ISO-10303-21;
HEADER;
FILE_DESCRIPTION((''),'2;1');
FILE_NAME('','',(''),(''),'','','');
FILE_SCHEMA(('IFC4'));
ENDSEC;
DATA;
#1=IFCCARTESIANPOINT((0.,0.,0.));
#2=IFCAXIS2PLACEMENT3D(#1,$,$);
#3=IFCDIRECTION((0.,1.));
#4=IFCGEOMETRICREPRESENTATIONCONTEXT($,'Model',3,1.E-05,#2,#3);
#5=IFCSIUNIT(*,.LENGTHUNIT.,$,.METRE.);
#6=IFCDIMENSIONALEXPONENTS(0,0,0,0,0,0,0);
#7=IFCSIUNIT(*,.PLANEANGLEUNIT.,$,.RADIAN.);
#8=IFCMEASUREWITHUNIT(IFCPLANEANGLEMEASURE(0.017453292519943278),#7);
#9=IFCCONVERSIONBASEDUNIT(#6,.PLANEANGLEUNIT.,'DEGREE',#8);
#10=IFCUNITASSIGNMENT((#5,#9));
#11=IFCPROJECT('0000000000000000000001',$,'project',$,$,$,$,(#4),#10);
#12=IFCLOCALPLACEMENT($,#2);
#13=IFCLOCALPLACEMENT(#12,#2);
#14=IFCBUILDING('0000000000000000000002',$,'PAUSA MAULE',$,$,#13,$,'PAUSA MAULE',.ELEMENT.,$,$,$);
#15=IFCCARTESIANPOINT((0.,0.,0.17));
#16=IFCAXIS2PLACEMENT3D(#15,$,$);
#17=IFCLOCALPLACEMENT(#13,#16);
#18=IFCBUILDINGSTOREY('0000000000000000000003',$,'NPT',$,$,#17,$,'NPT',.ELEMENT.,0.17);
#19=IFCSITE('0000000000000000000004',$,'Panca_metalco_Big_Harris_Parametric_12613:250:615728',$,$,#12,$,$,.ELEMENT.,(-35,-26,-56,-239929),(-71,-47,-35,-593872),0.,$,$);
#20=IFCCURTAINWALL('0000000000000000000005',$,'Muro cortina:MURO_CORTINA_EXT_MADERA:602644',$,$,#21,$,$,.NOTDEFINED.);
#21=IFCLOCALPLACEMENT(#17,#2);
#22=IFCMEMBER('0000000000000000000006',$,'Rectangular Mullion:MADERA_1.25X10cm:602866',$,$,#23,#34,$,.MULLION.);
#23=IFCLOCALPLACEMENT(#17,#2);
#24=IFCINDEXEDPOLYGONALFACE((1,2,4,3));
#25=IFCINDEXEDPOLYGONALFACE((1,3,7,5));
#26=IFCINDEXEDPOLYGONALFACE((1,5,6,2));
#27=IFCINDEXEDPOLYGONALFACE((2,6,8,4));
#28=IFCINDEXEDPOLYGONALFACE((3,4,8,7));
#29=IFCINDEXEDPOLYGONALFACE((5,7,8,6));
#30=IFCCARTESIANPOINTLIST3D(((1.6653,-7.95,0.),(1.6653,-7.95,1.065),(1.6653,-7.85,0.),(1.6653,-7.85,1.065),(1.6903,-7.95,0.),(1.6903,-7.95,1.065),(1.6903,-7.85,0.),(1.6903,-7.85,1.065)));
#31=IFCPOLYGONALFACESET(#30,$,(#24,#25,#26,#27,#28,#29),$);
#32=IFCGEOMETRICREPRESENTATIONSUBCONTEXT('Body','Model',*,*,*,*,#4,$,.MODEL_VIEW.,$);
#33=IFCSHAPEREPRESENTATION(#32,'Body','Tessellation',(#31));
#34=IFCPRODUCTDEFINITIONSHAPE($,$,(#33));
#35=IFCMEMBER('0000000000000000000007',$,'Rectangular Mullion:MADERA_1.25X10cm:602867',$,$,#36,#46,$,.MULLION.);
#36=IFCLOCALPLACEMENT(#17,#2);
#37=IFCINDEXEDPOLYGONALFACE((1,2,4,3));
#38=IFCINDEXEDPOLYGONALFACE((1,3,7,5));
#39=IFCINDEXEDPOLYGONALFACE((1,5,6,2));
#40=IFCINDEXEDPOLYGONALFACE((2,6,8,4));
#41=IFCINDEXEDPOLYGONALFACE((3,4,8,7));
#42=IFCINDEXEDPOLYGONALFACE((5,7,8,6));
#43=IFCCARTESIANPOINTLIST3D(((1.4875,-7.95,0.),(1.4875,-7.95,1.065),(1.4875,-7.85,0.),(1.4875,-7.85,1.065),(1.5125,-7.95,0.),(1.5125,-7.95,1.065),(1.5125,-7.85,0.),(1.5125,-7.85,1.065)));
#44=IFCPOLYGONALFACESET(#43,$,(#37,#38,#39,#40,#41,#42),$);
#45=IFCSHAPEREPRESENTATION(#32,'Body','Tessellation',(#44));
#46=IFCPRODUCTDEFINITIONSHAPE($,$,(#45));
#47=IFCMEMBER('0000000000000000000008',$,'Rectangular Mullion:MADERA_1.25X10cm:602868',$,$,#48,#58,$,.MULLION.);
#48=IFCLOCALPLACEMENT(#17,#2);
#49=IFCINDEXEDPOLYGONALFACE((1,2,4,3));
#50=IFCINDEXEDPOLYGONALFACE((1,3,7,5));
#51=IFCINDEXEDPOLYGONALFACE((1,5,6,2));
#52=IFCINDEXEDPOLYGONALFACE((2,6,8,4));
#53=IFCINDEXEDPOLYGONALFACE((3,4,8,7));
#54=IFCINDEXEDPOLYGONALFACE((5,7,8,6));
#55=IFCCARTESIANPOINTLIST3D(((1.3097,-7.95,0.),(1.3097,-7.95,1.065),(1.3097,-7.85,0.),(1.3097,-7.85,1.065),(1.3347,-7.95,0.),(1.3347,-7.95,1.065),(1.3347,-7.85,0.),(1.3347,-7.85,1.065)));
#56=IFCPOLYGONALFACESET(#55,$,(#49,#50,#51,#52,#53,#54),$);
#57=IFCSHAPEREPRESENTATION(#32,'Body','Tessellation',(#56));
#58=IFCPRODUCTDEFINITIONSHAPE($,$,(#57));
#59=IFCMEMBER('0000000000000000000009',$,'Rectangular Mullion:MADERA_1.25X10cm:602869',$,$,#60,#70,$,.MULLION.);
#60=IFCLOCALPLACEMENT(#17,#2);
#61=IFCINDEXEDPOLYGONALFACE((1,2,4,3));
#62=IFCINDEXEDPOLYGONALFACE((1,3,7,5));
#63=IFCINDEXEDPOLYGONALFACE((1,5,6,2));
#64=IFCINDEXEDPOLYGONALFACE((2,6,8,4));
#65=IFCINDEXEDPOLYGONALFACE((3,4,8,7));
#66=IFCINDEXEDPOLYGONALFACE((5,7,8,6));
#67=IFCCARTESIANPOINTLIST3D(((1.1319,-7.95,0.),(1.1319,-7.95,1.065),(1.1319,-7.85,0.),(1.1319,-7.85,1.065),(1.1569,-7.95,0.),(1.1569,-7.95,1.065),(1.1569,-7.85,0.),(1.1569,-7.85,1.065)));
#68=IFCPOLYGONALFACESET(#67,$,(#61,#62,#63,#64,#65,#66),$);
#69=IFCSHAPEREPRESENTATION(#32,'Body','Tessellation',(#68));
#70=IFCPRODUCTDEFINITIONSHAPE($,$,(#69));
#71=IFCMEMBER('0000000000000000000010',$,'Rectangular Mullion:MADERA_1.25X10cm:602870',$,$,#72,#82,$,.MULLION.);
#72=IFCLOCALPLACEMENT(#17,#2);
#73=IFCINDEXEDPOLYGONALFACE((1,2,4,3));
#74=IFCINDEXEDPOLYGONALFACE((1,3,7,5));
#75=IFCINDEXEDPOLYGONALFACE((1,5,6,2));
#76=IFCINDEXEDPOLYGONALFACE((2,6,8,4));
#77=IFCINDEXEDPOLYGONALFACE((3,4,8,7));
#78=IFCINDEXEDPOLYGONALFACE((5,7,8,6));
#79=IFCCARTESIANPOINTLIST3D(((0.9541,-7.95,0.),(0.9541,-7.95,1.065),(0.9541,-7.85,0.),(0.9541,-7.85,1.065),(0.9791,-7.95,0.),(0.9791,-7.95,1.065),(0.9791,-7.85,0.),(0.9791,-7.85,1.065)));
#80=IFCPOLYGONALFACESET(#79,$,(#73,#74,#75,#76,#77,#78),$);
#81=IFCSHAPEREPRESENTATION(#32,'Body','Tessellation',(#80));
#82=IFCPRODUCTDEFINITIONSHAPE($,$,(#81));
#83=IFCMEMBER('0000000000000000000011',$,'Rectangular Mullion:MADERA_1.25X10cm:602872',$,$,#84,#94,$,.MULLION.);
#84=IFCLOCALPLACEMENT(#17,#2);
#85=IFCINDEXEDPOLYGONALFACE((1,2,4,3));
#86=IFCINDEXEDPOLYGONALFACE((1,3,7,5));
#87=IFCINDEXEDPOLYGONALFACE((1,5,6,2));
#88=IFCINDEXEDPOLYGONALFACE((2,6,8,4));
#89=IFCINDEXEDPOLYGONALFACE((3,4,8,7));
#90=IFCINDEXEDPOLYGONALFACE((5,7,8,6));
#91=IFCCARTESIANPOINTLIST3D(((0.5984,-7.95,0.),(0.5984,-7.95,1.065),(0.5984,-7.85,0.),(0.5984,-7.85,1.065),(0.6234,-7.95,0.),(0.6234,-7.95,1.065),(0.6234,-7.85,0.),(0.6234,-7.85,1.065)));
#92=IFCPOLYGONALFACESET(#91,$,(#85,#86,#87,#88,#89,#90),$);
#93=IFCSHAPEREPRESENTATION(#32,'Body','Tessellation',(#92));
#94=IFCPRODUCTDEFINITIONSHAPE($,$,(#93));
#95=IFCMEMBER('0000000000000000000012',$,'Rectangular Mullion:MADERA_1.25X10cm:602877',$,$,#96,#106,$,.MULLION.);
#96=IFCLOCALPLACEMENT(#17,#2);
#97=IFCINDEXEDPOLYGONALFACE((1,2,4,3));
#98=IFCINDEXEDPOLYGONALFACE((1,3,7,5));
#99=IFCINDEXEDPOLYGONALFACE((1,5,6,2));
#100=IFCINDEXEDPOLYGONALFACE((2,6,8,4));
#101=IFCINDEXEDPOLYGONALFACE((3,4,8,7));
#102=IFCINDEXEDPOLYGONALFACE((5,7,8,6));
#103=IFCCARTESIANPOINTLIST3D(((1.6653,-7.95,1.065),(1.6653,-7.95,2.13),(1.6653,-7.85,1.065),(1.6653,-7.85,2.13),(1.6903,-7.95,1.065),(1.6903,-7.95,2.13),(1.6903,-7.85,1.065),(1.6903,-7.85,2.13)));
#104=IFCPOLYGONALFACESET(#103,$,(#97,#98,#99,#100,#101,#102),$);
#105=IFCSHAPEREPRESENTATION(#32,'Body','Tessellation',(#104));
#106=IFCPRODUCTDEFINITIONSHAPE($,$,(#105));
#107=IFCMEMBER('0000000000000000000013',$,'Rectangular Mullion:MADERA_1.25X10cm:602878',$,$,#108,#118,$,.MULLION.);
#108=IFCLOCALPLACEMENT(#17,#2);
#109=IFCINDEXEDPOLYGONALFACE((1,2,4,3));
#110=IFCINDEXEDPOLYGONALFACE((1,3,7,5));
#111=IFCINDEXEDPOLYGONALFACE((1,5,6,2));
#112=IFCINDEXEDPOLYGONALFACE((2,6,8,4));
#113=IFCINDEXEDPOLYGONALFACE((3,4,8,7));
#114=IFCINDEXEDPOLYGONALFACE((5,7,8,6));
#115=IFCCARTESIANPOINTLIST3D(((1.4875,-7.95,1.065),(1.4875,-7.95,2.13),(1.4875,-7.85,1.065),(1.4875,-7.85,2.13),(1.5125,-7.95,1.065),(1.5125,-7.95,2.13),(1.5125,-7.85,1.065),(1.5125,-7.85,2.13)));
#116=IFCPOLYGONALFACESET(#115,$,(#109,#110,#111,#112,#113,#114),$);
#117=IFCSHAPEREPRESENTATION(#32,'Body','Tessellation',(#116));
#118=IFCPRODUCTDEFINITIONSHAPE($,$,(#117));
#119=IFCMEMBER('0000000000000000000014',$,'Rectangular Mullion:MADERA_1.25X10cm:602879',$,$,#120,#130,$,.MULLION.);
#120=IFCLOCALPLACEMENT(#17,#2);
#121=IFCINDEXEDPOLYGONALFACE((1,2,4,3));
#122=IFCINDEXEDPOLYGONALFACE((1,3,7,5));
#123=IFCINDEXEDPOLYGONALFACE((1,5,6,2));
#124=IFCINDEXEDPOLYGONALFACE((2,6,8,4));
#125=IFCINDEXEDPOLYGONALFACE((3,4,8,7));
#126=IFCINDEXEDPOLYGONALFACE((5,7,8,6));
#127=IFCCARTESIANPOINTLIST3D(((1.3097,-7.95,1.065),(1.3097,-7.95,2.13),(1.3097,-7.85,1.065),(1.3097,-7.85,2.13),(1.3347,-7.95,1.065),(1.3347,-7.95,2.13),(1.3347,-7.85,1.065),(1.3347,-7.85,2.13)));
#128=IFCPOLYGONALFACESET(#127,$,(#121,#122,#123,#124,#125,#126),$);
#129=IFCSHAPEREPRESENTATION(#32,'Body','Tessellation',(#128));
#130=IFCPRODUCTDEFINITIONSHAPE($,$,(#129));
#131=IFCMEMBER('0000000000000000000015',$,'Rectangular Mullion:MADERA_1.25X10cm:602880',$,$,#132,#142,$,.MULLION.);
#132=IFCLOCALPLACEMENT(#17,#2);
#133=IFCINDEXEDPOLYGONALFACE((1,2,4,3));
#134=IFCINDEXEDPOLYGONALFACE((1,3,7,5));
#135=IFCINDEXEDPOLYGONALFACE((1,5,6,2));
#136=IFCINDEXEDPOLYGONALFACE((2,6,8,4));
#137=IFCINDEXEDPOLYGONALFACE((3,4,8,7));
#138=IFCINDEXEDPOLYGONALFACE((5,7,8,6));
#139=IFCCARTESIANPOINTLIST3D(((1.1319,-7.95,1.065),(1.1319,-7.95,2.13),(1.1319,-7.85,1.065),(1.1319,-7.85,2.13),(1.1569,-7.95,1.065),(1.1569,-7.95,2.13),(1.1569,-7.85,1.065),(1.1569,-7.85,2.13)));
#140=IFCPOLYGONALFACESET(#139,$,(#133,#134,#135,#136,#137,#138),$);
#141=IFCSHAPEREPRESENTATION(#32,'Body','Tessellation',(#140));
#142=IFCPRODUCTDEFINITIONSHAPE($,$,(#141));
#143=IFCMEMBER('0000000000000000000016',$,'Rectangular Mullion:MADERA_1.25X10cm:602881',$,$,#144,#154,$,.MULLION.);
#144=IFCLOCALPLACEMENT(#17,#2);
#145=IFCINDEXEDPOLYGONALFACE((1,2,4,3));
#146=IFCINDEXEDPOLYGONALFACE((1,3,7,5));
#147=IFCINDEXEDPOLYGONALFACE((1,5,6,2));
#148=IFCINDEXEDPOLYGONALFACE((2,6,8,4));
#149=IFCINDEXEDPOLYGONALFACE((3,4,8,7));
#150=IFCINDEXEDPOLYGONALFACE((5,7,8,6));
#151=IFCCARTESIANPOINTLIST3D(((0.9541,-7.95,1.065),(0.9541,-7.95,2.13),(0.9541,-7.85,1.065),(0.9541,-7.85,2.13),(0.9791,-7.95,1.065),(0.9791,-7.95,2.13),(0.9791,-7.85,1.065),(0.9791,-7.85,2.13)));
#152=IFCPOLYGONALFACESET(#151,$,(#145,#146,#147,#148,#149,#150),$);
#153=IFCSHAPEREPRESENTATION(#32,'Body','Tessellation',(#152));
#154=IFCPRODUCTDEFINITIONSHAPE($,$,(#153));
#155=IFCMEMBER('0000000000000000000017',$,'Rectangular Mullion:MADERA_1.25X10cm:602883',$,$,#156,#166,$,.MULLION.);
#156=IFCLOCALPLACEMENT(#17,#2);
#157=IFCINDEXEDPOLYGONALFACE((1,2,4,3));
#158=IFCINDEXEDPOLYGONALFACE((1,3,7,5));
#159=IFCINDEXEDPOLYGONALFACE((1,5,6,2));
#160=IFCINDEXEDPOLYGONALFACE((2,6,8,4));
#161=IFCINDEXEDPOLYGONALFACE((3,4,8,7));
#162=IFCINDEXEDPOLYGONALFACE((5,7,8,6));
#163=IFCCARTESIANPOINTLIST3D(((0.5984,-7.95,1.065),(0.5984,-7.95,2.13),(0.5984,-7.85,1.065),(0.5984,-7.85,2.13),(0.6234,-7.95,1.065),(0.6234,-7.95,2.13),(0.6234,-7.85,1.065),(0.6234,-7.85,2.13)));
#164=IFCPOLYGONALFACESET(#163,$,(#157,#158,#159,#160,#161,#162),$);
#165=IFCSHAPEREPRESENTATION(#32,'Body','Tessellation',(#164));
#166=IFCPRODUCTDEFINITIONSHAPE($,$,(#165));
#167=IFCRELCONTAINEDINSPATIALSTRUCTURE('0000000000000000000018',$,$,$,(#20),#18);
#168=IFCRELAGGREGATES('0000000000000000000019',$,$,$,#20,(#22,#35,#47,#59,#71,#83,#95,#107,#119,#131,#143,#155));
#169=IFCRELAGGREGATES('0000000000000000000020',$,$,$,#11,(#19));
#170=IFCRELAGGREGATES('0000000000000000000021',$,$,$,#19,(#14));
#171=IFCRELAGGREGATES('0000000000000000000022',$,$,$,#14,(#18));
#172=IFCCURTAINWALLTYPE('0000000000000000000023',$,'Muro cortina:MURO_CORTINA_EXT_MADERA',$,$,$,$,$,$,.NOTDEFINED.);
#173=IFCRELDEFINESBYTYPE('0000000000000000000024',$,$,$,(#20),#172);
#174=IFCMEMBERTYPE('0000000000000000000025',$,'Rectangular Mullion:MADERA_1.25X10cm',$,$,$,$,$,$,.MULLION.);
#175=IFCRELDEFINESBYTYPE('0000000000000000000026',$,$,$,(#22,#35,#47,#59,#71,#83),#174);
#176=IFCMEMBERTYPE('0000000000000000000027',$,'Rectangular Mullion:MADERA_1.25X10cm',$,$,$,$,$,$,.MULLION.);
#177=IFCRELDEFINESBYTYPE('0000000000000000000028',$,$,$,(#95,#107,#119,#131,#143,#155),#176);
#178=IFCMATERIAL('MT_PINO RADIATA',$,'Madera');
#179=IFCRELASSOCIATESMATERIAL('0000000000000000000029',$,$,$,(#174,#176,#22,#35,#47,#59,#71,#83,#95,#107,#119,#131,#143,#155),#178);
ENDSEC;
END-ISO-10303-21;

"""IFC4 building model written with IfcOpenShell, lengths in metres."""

from ifc_helpers import new_model, entity, si_unit, converted_unit, direction, frame, frame_2d, origin, place, context, subcontext, project, spatial, rectangle, extrude, source, transform, mapped, material, material_profile, profile_set, profile_usage, type_object, type_shapes, element, aggregate, save


model = new_model("IFC4")

# Units and contexts
model_context = context("Model", 3, precision=1e-05, world=origin(), true_north=direction((0.0, 1.0)))
body_context = subcontext(model_context, "Body", "Model", "MODEL_VIEW")
ifc_project = project(units=[si_unit("LENGTHUNIT", "METRE"), converted_unit("PLANEANGLEUNIT", "DEGREE", entity("IfcPlaneAngleMeasure", 0.017453292519943278), si_unit("PLANEANGLEUNIT", "RADIAN"), dimensions=[0, 0, 0, 0, 0, 0, 0])], contexts=[model_context])

# Site, building, storey
site_placement = place(None, origin())
site = spatial("IfcSite", under=ifc_project, at=site_placement, Name="Panca_metalco_Big_Harris_Parametric_12613:250:615728", CompositionType="ELEMENT", RefLatitude=(-35, -26, -56, -239929), RefLongitude=(-71, -47, -35, -593872), RefElevation=0.0)
building_placement = place(site_placement, origin())
building = spatial("IfcBuilding", under=site, at=building_placement, Name="PAUSA MAULE", LongName="PAUSA MAULE", CompositionType="ELEMENT")
storey_placement = place(building_placement, frame((0.0, 0.0, 0.17)))
storey = spatial("IfcBuildingStorey", under=building, at=storey_placement, Name="NPT", LongName="NPT", CompositionType="ELEMENT", Elevation=0.17)

# Curtain wall, members
curtain_wall_type = type_object("IfcCurtainWallType", Name="Muro cortina:MURO_CORTINA_EXT_MADERA", PredefinedType="NOTDEFINED")
curtain_wall_placement = place(storey_placement, frame((0.0, 0.0, -0.17)))
curtain_wall = element("IfcCurtainWall", 1, at=curtain_wall_placement, inside=storey, type_object=curtain_wall_type, Name="Muro cortina:MURO_CORTINA_EXT_MADERA:602644", PredefinedType="NOTDEFINED")
ifc_material = material(Name="MT_PINO RADIATA", Category="Madera")
ifc_material_profile = material_profile(ifc_material, rectangle(XDim=0.025, YDim=0.1, at=frame_2d((0.0, 0.0), x_axis=(1.0, 0.0))), Name="MADERA_1.25X10cm")
ifc_profile_set = profile_set([ifc_material_profile], Name="MADERA_1.25X10cm")
ifc_profile_usage = profile_usage(ifc_profile_set)
member_type_1 = type_object("IfcMemberType", Name="Rectangular Mullion:MADERA_1.25X10cm", PredefinedType="MULLION", material=ifc_profile_set)
shared_shape_1 = source(origin(), body_context, "Body", "SweptSolid", [
    extrude(rectangle(XDim=0.025, YDim=0.1, at=frame_2d((0.0, 0.0), x_axis=(1.0, 0.0))), frame((0.0, 0.0, -1.065), z_axis=(0.0, 0.0, 1.0), x_axis=(-1.0, 0.0, 0.0)), (0.0, 0.0, 1.0), 1.065),
])
type_shapes(member_type_1, [shared_shape_1])
member_1_placement = place(curtain_wall_placement, frame((1.6778, -7.9, 0.17), z_axis=(0.0, 0.0, -1.0), x_axis=(-1.0, 0.0, 0.0)))
member_1 = element("IfcMember", 2, at=member_1_placement, type_object=member_type_1, material=ifc_profile_usage, Name="Rectangular Mullion:MADERA_1.25X10cm:602866", PredefinedType="MULLION", context=body_context, shape_type="MappedRepresentation", body=[
    mapped(shared_shape_1, transform((0.0, 0.0, 0.0), scale=1.0)),
])
member_2_placement = place(curtain_wall_placement, frame((1.5, -7.9, 0.17), z_axis=(0.0, 0.0, -1.0), x_axis=(-1.0, 0.0, 0.0)))
member_2 = element("IfcMember", 3, at=member_2_placement, type_object=member_type_1, material=ifc_profile_usage, Name="Rectangular Mullion:MADERA_1.25X10cm:602867", PredefinedType="MULLION", context=body_context, shape_type="MappedRepresentation", body=[
    mapped(shared_shape_1, transform((0.0, 0.0, 0.0), scale=1.0)),
])
member_3_placement = place(curtain_wall_placement, frame((1.3222, -7.9, 0.17), z_axis=(0.0, 0.0, -1.0), x_axis=(-1.0, 0.0, 0.0)))
member_3 = element("IfcMember", 4, at=member_3_placement, type_object=member_type_1, material=ifc_profile_usage, Name="Rectangular Mullion:MADERA_1.25X10cm:602868", PredefinedType="MULLION", context=body_context, shape_type="MappedRepresentation", body=[
    mapped(shared_shape_1, transform((0.0, 0.0, 0.0), scale=1.0)),
])
member_4_placement = place(curtain_wall_placement, frame((1.1444, -7.9, 0.17), z_axis=(0.0, 0.0, -1.0), x_axis=(-1.0, 0.0, 0.0)))
member_4 = element("IfcMember", 5, at=member_4_placement, type_object=member_type_1, material=ifc_profile_usage, Name="Rectangular Mullion:MADERA_1.25X10cm:602869", PredefinedType="MULLION", context=body_context, shape_type="MappedRepresentation", body=[
    mapped(shared_shape_1, transform((0.0, 0.0, 0.0), scale=1.0)),
])
member_5_placement = place(curtain_wall_placement, frame((0.9666, -7.9, 0.17), z_axis=(0.0, 0.0, -1.0), x_axis=(-1.0, 0.0, 0.0)))
member_5 = element("IfcMember", 6, at=member_5_placement, type_object=member_type_1, material=ifc_profile_usage, Name="Rectangular Mullion:MADERA_1.25X10cm:602870", PredefinedType="MULLION", context=body_context, shape_type="MappedRepresentation", body=[
    mapped(shared_shape_1, transform((0.0, 0.0, 0.0), scale=1.0)),
])
member_6_placement = place(curtain_wall_placement, frame((0.6109, -7.9, 0.17), z_axis=(0.0, 0.0, -1.0), x_axis=(-1.0, 0.0, 0.0)))
member_6 = element("IfcMember", 7, at=member_6_placement, type_object=member_type_1, material=ifc_profile_usage, Name="Rectangular Mullion:MADERA_1.25X10cm:602872", PredefinedType="MULLION", context=body_context, shape_type="MappedRepresentation", body=[
    mapped(shared_shape_1, transform((0.0, 0.0, 0.0), scale=1.0)),
])
member_type_2 = type_object("IfcMemberType", Name="Rectangular Mullion:MADERA_1.25X10cm", PredefinedType="MULLION", material=ifc_profile_set)
shared_shape_2 = source(origin(), body_context, "Body", "SweptSolid", [
    extrude(rectangle(XDim=0.025, YDim=0.1, at=frame_2d((0.0, 0.0), x_axis=(1.0, 0.0))), frame((0.0, 0.0, -1.065), z_axis=(0.0, 0.0, 1.0), x_axis=(-1.0, 0.0, 0.0)), (0.0, 0.0, 1.0), 1.065),
])
type_shapes(member_type_2, [shared_shape_2])
member_7_placement = place(curtain_wall_placement, frame((1.6778, -7.9, 1.235), z_axis=(0.0, 0.0, -1.0), x_axis=(-1.0, 0.0, 0.0)))
member_7 = element("IfcMember", 8, at=member_7_placement, type_object=member_type_2, material=ifc_profile_usage, Name="Rectangular Mullion:MADERA_1.25X10cm:602877", PredefinedType="MULLION", context=body_context, shape_type="MappedRepresentation", body=[
    mapped(shared_shape_2, transform((0.0, 0.0, 0.0), scale=1.0)),
])
member_8_placement = place(curtain_wall_placement, frame((1.5, -7.9, 1.235), z_axis=(0.0, 0.0, -1.0), x_axis=(-1.0, 0.0, 0.0)))
member_8 = element("IfcMember", 9, at=member_8_placement, type_object=member_type_2, material=ifc_profile_usage, Name="Rectangular Mullion:MADERA_1.25X10cm:602878", PredefinedType="MULLION", context=body_context, shape_type="MappedRepresentation", body=[
    mapped(shared_shape_2, transform((0.0, 0.0, 0.0), scale=1.0)),
])
member_9_placement = place(curtain_wall_placement, frame((1.3222, -7.9, 1.235), z_axis=(0.0, 0.0, -1.0), x_axis=(-1.0, 0.0, 0.0)))
member_9 = element("IfcMember", 10, at=member_9_placement, type_object=member_type_2, material=ifc_profile_usage, Name="Rectangular Mullion:MADERA_1.25X10cm:602879", PredefinedType="MULLION", context=body_context, shape_type="MappedRepresentation", body=[
    mapped(shared_shape_2, transform((0.0, 0.0, 0.0), scale=1.0)),
])
member_10_placement = place(curtain_wall_placement, frame((1.1444, -7.9, 1.235), z_axis=(0.0, 0.0, -1.0), x_axis=(-1.0, 0.0, 0.0)))
member_10 = element("IfcMember", 11, at=member_10_placement, type_object=member_type_2, material=ifc_profile_usage, Name="Rectangular Mullion:MADERA_1.25X10cm:602880", PredefinedType="MULLION", context=body_context, shape_type="MappedRepresentation", body=[
    mapped(shared_shape_2, transform((0.0, 0.0, 0.0), scale=1.0)),
])
member_11_placement = place(curtain_wall_placement, frame((0.9666, -7.9, 1.235), z_axis=(0.0, 0.0, -1.0), x_axis=(-1.0, 0.0, 0.0)))
member_11 = element("IfcMember", 12, at=member_11_placement, type_object=member_type_2, material=ifc_profile_usage, Name="Rectangular Mullion:MADERA_1.25X10cm:602881", PredefinedType="MULLION", context=body_context, shape_type="MappedRepresentation", body=[
    mapped(shared_shape_2, transform((0.0, 0.0, 0.0), scale=1.0)),
])
member_12_placement = place(curtain_wall_placement, frame((0.6109, -7.9, 1.235), z_axis=(0.0, 0.0, -1.0), x_axis=(-1.0, 0.0, 0.0)))
member_12 = element("IfcMember", 13, at=member_12_placement, type_object=member_type_2, material=ifc_profile_usage, Name="Rectangular Mullion:MADERA_1.25X10cm:602883", PredefinedType="MULLION", context=body_context, shape_type="MappedRepresentation", body=[
    mapped(shared_shape_2, transform((0.0, 0.0, 0.0), scale=1.0)),
])
aggregate(curtain_wall, [member_1, member_2, member_3, member_4, member_5, member_6, member_7, member_8, member_9, member_10, member_11, member_12])

save(model, "model.ifc")
